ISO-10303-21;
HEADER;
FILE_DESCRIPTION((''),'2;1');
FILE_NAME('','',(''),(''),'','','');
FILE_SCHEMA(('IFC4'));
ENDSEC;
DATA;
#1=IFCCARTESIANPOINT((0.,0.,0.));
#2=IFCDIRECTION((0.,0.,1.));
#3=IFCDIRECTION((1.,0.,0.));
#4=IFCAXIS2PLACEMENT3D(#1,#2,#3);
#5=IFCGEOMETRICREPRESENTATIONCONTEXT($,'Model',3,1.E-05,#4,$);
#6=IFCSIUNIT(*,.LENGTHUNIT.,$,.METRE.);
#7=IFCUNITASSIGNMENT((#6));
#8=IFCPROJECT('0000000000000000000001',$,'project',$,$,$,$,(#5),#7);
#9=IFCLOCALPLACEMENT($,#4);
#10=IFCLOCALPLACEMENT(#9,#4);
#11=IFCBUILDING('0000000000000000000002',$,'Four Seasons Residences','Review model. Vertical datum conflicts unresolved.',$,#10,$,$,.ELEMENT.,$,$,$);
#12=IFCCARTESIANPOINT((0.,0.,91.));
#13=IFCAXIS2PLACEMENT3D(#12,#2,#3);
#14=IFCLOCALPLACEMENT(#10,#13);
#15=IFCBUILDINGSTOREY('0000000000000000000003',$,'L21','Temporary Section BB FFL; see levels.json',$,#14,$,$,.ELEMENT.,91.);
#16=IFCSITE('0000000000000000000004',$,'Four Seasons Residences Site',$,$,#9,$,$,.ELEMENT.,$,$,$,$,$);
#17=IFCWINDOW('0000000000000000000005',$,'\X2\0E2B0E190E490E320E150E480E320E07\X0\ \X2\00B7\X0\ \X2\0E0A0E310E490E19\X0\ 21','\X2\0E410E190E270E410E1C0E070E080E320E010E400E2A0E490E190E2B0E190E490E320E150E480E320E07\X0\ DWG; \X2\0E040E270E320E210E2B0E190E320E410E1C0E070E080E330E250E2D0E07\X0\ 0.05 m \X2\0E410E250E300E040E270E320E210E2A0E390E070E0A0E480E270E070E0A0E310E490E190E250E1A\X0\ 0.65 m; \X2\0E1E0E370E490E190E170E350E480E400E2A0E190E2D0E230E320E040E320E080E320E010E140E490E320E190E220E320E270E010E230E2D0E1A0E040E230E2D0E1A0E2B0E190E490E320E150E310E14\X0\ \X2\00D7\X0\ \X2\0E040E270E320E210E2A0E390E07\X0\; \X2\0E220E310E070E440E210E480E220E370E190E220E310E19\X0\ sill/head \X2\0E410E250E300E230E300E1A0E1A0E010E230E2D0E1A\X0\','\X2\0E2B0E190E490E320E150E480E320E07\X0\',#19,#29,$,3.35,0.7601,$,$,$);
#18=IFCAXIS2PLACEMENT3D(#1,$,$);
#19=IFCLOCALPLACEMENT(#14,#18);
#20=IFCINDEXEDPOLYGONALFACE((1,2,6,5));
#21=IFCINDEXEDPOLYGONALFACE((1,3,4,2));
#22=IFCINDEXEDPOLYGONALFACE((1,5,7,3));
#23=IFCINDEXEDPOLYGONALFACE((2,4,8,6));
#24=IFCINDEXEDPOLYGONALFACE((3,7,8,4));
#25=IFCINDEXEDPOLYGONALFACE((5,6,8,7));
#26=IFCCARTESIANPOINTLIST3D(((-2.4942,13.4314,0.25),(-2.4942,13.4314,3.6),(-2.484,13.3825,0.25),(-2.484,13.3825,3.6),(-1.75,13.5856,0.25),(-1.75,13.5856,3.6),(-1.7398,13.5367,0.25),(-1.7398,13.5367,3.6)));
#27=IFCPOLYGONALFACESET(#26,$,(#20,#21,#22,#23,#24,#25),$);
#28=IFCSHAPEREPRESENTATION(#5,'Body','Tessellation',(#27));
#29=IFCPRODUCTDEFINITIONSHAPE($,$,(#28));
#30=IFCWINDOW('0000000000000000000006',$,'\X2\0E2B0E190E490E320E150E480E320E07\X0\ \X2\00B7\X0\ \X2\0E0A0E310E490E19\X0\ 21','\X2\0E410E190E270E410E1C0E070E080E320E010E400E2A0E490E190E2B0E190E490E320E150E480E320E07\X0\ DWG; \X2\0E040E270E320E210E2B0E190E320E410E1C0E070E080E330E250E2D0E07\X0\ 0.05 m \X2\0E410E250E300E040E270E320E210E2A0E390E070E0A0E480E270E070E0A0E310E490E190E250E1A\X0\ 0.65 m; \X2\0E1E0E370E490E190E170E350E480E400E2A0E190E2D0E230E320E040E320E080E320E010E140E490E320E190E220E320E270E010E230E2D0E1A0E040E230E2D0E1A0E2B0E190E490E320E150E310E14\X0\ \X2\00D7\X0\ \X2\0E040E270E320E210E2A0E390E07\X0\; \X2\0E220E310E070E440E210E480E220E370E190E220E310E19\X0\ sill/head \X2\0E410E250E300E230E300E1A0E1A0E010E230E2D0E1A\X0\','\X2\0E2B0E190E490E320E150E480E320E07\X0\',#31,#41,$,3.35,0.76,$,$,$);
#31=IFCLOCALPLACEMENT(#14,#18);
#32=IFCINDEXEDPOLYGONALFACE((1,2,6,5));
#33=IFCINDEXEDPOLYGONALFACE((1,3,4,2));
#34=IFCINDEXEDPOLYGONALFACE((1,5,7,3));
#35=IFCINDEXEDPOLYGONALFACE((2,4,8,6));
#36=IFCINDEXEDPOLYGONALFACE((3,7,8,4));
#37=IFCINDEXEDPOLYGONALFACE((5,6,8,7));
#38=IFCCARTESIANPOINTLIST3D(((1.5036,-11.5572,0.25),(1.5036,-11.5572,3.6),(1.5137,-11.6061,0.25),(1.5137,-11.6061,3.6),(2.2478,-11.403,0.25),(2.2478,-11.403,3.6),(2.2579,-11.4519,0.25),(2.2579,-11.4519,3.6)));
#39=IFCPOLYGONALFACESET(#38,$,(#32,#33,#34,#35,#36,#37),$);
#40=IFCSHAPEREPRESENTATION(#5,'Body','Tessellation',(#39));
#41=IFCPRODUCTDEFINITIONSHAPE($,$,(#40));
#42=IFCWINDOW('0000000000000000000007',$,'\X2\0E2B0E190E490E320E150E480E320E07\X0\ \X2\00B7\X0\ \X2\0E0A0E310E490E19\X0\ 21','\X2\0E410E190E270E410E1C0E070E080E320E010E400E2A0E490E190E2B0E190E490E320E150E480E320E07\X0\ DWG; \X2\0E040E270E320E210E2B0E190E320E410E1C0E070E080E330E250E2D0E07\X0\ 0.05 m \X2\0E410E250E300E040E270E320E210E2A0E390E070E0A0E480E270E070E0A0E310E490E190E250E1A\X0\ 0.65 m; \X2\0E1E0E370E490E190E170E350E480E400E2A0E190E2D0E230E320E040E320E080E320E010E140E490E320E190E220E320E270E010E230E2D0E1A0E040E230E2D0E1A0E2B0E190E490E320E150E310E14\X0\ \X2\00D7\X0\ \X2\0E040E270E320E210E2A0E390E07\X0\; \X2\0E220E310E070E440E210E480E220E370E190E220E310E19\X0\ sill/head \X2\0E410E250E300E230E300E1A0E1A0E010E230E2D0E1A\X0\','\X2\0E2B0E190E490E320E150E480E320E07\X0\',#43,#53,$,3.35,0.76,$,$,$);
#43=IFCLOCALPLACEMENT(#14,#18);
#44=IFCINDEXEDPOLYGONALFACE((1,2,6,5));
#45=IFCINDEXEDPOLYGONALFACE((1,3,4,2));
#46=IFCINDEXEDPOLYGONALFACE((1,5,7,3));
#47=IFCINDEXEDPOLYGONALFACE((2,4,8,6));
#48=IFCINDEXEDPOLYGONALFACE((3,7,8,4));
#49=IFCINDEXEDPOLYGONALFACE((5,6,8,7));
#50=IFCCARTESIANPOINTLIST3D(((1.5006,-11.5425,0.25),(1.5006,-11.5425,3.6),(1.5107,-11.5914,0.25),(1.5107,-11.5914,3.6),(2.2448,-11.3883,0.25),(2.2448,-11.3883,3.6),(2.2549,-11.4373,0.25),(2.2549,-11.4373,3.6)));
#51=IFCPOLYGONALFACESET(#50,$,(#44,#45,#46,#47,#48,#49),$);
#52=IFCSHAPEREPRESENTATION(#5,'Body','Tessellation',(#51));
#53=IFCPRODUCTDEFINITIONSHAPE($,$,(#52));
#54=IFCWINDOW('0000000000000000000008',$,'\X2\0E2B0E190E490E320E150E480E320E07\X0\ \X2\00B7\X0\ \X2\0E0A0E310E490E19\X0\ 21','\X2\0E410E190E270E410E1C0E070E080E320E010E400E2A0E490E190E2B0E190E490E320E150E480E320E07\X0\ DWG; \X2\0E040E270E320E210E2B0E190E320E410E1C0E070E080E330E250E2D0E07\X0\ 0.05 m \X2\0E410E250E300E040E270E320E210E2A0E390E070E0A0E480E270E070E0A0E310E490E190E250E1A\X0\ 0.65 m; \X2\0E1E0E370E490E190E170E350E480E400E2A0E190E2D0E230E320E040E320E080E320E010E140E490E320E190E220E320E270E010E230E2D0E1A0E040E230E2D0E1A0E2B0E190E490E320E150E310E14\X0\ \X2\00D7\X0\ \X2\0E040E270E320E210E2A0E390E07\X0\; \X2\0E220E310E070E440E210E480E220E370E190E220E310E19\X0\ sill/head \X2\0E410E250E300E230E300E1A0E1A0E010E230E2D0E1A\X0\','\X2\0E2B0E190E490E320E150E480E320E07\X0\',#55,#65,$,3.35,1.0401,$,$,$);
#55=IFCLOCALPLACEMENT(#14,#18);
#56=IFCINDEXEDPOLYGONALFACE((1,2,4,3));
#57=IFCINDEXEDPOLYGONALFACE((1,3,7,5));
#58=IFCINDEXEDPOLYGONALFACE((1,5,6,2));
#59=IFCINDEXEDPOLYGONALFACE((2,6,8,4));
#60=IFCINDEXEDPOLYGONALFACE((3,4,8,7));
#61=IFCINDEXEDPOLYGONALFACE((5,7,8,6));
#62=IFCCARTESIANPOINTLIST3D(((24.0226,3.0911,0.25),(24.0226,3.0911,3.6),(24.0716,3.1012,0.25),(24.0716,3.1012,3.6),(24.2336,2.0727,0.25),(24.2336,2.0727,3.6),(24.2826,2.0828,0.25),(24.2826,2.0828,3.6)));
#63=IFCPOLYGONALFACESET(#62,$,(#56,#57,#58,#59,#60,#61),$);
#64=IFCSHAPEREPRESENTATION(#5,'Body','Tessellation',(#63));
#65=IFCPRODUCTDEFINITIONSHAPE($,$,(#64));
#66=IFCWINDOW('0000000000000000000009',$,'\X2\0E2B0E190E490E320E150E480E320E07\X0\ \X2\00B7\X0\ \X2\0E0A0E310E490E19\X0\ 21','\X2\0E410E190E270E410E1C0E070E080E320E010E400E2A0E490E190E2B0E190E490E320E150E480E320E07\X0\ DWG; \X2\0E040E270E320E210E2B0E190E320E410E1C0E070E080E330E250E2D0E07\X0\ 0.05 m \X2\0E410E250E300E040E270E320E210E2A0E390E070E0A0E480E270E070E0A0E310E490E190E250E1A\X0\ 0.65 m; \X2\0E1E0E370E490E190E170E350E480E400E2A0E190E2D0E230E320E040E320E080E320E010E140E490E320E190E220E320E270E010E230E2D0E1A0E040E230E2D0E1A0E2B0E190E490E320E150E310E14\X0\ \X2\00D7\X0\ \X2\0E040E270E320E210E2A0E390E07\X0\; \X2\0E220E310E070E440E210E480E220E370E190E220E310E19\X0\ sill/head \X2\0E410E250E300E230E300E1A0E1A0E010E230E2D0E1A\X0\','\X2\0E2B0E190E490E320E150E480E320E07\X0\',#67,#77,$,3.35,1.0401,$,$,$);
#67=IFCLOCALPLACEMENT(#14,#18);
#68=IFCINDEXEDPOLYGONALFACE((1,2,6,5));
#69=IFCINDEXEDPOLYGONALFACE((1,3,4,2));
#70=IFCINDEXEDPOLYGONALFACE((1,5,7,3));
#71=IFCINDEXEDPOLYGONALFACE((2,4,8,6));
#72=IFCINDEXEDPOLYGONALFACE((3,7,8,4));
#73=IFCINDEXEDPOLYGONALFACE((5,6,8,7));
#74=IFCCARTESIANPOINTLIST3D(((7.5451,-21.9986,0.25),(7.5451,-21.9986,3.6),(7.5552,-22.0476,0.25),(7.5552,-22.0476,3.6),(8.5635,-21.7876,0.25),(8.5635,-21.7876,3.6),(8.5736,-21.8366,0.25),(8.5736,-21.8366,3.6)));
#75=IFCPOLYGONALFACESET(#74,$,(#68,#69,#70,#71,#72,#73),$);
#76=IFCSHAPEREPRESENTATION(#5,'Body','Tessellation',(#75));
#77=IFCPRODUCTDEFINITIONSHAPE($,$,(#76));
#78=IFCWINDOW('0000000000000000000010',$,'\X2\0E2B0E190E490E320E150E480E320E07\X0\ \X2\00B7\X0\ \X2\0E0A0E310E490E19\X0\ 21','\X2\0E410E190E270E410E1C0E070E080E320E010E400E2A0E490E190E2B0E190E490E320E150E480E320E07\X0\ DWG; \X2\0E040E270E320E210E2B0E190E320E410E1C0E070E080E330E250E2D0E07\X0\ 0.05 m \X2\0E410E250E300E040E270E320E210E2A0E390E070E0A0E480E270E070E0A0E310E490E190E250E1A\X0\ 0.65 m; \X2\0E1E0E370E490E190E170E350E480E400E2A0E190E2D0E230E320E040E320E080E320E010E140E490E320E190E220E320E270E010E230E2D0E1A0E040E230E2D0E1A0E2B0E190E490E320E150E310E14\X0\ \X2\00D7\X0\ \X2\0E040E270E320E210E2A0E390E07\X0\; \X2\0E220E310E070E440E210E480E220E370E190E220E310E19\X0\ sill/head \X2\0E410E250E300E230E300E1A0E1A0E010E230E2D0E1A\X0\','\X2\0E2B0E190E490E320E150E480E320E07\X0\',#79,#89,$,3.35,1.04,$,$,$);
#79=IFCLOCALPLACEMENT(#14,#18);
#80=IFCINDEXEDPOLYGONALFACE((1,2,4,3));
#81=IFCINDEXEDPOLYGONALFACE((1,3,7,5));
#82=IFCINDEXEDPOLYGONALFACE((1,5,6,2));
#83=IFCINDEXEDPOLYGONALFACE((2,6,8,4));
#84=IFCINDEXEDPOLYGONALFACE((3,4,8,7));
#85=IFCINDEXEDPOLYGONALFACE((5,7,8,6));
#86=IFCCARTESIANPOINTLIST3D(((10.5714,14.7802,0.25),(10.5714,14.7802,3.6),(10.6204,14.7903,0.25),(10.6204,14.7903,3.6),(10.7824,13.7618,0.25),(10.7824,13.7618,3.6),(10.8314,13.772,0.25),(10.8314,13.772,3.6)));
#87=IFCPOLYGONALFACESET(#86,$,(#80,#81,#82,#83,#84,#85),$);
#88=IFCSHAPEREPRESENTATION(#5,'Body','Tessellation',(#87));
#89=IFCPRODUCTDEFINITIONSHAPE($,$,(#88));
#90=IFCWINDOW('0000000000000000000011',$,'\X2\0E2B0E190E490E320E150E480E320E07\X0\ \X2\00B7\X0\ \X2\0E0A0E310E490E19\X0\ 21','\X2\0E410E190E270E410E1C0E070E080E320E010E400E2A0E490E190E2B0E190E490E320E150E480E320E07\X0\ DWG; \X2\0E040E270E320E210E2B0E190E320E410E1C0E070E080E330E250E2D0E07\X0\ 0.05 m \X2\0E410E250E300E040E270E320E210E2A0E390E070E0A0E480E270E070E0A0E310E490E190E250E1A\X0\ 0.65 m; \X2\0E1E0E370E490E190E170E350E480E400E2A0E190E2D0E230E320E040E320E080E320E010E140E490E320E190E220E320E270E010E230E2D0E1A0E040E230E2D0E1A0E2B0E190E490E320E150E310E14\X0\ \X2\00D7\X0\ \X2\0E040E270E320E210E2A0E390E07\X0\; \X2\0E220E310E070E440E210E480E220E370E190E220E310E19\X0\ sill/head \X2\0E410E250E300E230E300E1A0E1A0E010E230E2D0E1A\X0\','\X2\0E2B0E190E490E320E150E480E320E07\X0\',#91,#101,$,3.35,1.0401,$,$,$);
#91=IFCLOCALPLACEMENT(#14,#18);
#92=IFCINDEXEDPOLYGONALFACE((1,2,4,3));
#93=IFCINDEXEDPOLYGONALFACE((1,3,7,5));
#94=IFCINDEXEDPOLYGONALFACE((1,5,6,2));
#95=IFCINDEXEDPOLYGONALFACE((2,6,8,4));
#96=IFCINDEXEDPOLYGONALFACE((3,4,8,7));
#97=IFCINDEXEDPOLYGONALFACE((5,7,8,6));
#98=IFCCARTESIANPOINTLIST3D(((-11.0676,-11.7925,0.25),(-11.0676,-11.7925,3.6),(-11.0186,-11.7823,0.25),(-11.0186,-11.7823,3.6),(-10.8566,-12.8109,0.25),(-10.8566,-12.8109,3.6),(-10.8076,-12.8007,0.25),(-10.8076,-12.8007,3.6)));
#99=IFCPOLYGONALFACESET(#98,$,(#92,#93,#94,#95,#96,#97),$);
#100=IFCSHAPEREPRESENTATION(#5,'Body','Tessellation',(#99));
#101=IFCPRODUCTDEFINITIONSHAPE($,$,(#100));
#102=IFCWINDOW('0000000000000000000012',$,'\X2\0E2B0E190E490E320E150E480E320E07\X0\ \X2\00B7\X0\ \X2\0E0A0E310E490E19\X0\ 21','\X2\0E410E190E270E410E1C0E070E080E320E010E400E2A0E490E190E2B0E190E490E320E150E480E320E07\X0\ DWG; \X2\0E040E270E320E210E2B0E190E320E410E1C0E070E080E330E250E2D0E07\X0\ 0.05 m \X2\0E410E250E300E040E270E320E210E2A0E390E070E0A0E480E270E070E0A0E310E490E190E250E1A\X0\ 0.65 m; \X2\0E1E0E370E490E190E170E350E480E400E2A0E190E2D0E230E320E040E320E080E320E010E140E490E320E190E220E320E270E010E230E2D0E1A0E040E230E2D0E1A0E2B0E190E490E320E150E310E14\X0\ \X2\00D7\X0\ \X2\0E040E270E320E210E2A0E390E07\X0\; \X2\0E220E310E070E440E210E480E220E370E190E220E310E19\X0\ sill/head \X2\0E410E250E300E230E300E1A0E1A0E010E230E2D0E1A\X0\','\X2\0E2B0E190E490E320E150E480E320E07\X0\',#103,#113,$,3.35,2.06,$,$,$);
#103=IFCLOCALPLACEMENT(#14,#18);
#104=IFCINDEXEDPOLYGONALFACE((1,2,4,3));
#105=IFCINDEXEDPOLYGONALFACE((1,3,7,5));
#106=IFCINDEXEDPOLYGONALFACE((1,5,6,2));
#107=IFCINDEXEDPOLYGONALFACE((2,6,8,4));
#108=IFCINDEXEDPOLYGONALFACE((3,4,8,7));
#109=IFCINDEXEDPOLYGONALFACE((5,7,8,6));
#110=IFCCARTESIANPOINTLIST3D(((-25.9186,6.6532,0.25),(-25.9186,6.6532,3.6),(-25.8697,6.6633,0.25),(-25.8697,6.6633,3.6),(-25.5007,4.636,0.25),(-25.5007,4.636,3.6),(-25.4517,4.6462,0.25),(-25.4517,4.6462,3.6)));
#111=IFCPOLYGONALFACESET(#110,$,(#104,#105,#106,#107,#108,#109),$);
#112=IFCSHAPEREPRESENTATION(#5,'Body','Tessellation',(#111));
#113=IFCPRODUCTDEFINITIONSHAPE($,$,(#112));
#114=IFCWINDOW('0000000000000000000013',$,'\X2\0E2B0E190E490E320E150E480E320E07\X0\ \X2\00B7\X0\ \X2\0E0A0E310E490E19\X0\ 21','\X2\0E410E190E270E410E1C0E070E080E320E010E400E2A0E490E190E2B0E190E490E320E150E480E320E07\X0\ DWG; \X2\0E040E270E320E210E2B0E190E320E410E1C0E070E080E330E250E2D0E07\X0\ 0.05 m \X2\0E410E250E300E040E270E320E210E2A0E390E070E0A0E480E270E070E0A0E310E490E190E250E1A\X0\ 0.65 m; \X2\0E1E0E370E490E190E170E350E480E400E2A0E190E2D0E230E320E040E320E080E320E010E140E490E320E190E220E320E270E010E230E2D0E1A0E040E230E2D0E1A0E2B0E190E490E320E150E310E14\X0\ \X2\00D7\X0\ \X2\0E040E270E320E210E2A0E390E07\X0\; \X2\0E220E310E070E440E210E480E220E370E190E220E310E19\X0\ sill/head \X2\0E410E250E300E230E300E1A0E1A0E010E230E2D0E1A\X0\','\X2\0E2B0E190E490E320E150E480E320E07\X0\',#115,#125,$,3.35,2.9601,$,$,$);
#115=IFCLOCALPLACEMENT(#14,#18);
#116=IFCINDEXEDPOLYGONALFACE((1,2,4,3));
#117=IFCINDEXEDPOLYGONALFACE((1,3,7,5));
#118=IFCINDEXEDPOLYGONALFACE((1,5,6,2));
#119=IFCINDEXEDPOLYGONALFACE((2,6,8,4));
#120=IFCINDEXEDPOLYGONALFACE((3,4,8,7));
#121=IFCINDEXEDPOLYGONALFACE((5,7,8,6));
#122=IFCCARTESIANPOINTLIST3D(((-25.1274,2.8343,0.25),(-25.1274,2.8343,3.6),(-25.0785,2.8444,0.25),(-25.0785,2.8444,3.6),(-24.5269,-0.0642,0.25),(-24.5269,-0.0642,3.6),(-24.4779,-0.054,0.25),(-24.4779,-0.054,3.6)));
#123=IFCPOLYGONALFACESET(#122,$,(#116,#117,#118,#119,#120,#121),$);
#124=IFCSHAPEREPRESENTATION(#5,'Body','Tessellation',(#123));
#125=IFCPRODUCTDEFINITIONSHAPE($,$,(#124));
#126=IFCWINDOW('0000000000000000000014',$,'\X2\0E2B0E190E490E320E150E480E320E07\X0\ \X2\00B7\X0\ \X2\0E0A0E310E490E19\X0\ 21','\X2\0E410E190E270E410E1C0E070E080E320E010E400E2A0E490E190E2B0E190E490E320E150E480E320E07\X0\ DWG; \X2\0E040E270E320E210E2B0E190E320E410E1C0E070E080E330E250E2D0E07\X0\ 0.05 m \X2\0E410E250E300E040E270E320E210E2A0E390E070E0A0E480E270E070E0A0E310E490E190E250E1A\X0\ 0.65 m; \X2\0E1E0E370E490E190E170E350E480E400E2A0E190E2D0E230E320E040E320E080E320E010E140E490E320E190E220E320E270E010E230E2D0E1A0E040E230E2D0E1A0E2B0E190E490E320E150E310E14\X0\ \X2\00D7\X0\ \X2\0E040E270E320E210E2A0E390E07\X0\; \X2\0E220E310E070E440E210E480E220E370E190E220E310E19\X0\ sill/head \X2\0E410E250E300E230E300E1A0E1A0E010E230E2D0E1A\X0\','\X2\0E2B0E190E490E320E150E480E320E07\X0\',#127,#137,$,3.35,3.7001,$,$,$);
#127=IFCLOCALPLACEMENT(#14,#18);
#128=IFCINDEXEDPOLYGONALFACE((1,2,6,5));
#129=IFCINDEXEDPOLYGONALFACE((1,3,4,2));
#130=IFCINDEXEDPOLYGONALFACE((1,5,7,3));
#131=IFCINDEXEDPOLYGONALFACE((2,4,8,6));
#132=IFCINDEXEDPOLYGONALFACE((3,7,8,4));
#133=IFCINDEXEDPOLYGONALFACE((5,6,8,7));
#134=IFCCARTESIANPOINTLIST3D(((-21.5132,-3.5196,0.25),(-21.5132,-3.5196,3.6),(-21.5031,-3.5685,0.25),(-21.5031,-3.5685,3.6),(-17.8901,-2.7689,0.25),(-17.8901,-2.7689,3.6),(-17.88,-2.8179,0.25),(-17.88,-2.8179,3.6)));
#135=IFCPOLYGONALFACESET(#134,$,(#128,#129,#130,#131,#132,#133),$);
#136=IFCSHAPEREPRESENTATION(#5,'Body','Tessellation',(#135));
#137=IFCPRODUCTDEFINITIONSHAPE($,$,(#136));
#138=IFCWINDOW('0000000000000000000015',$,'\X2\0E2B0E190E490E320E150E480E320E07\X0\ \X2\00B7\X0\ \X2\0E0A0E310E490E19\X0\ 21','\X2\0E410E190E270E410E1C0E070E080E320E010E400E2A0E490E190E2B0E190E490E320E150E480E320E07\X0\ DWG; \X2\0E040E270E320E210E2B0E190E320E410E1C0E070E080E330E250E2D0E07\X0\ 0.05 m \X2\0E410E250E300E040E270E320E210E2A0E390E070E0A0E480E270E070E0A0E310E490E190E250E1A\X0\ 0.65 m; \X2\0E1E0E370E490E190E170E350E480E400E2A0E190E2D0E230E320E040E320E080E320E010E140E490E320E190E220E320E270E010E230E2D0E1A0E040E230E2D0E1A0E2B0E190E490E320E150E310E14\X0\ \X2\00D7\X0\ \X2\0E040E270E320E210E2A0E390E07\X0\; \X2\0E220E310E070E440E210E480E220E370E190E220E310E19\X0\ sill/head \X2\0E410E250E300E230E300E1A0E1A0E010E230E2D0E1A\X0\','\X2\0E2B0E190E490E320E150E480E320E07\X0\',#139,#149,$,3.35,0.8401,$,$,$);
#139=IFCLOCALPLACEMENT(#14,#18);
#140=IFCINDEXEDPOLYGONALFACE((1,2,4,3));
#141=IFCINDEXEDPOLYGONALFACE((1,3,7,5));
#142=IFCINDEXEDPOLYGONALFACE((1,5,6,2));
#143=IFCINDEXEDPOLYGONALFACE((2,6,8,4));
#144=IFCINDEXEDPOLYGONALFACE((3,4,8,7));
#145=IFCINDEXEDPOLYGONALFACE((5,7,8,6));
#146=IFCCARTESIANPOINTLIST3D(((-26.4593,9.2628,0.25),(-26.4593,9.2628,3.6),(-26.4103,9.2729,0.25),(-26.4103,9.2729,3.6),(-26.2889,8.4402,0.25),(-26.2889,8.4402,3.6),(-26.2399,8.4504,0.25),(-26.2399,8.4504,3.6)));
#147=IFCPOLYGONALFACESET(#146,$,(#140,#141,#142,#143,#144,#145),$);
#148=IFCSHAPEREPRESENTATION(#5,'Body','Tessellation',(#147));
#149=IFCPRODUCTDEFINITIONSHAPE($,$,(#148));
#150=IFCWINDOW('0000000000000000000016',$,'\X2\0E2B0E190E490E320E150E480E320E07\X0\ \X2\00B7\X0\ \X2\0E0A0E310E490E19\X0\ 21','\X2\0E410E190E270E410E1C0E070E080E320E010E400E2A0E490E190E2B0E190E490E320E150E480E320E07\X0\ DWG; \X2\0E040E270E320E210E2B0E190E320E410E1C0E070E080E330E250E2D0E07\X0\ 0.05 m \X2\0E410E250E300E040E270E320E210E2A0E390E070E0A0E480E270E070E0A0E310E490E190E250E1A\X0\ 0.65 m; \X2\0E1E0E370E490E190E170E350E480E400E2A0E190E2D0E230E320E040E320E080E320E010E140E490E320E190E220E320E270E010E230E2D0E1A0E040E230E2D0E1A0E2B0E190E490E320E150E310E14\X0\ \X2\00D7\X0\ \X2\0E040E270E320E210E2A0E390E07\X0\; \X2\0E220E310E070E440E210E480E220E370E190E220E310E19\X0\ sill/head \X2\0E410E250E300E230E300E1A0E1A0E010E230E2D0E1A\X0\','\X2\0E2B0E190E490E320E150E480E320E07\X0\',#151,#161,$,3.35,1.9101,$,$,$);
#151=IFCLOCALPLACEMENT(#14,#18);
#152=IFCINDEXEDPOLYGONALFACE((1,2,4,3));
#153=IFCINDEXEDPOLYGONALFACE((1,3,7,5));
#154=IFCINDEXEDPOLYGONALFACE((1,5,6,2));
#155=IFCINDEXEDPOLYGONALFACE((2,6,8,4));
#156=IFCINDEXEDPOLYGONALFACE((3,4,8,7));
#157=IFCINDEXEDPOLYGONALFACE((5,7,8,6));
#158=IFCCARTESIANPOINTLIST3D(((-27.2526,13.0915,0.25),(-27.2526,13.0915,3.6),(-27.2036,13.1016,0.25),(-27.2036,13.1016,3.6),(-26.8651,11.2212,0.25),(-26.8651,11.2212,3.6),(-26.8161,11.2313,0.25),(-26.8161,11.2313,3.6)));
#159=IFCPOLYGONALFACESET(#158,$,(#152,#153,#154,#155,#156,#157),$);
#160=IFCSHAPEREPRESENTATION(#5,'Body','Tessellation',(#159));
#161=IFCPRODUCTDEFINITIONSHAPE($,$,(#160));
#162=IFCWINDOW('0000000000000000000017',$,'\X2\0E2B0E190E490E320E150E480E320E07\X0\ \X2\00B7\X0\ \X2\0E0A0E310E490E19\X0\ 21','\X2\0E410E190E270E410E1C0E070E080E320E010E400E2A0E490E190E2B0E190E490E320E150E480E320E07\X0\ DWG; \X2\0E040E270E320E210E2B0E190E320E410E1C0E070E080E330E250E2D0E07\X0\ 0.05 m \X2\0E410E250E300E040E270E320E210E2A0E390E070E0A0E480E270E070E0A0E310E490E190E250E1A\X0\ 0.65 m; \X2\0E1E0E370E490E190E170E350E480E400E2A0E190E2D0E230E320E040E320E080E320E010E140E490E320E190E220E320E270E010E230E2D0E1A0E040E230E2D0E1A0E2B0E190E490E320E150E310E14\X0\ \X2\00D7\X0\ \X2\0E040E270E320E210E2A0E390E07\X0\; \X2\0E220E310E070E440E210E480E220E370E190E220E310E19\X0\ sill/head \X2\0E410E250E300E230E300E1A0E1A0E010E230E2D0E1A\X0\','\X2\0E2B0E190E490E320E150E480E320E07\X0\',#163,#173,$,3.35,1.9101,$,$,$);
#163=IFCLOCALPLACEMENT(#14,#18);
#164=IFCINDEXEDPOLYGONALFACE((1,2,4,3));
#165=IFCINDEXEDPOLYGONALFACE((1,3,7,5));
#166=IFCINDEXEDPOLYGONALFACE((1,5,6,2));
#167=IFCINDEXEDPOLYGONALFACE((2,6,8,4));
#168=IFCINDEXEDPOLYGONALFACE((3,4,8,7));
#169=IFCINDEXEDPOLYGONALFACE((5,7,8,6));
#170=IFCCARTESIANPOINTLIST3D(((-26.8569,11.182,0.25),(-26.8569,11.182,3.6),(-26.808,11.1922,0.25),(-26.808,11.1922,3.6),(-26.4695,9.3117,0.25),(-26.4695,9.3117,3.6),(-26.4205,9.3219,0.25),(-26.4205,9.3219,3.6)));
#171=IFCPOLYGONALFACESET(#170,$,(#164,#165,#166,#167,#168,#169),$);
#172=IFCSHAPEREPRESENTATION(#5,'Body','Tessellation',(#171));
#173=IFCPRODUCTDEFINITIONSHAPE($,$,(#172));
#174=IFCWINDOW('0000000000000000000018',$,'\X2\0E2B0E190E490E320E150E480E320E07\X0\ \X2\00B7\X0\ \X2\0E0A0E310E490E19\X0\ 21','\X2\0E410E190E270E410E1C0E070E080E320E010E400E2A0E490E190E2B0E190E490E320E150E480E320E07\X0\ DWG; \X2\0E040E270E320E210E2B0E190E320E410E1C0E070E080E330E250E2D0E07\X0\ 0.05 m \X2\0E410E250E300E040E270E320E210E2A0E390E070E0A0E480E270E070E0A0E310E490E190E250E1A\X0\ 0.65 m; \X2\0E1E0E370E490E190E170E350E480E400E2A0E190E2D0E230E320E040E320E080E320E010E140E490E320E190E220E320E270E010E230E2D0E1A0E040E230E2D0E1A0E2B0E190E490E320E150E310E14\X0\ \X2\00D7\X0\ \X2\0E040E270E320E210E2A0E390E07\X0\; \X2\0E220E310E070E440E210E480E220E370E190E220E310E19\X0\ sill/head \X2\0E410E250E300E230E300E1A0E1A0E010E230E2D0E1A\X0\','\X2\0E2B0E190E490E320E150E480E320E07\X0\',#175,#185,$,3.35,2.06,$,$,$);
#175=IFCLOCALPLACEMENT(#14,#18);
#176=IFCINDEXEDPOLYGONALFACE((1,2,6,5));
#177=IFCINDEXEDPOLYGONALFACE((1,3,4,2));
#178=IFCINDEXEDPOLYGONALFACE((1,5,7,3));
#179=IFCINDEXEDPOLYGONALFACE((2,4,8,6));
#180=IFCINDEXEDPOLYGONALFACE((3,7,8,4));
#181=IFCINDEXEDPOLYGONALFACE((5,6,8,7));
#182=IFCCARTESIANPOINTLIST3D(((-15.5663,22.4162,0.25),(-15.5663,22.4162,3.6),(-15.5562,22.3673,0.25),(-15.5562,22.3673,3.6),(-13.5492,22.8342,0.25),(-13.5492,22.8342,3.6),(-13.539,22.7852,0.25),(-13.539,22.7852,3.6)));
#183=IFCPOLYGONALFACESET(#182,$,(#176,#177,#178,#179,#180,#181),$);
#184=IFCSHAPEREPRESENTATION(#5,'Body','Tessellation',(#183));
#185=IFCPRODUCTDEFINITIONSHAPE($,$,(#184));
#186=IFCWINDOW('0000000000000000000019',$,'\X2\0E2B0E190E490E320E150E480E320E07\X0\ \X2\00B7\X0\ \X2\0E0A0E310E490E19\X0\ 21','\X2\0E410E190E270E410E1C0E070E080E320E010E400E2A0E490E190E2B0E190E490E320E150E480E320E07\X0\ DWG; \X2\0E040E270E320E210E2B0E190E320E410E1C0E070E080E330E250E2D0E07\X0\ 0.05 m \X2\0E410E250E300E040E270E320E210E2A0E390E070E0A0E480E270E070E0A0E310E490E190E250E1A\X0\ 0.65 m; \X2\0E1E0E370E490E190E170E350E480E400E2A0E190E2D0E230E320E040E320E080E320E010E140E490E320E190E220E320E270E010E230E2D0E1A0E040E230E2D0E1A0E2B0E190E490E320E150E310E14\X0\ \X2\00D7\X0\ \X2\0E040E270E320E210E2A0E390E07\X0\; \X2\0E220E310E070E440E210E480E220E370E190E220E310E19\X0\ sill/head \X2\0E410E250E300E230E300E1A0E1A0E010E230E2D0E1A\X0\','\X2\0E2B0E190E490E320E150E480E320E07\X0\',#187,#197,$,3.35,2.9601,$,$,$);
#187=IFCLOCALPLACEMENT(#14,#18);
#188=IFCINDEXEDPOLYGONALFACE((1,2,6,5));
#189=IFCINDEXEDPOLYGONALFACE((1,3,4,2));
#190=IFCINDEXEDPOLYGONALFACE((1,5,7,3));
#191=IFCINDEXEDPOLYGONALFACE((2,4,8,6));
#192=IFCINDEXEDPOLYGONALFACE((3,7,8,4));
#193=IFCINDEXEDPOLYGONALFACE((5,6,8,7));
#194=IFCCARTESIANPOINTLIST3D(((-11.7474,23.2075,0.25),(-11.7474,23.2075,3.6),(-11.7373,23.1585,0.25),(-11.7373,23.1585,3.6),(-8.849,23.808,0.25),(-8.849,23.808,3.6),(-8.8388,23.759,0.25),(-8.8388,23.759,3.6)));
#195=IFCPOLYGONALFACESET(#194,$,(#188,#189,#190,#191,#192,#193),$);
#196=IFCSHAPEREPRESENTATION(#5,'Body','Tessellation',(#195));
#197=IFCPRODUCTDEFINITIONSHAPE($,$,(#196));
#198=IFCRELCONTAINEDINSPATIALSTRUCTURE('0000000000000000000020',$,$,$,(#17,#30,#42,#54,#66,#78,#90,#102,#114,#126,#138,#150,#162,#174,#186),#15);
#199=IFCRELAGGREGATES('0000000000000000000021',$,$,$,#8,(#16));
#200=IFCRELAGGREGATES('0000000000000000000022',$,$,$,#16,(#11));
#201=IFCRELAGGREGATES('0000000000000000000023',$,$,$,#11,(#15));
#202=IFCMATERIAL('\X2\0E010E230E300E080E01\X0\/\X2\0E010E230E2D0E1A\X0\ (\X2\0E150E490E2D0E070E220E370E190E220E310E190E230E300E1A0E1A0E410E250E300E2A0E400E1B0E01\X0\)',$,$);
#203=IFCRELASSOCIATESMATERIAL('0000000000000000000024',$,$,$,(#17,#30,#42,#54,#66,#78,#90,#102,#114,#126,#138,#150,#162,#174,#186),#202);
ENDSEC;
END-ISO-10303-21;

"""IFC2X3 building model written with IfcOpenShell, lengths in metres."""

from ifc_helpers import new_model, si_unit, frame, origin_with_axes, place, context, project, spatial, polyline, outline, extrude, material, element, save


model = new_model("IFC2X3")

# Units and contexts
model_context = context("Model", 3, precision=1e-05, world=origin_with_axes())
ifc_project = project(units=[si_unit("LENGTHUNIT", "METRE")], contexts=[model_context])

# Site, building, storey
site_placement = place(None, origin_with_axes())
site = spatial("IfcSite", under=ifc_project, at=site_placement, Name="Four Seasons Residences Site", CompositionType="ELEMENT")
building_placement = place(site_placement, origin_with_axes())
building = spatial("IfcBuilding", under=site, at=building_placement, Name="Four Seasons Residences", Description="Review model. Vertical datum conflicts unresolved.", CompositionType="ELEMENT")
storey_placement = place(building_placement, frame((0.0, 0.0, 91.0), z_axis=(0.0, 0.0, 1.0), x_axis=(1.0, 0.0, 0.0)))
storey = spatial("IfcBuildingStorey", under=building, at=storey_placement, Name="L21", Description="Temporary Section BB FFL; see levels.json", CompositionType="ELEMENT", Elevation=91.0)

# Windows
ifc_material = material(Name="กระจก/กรอบ (ต้องยืนยันระบบและสเปก)")
window_1_placement = place(storey_placement, origin_with_axes())
element("IfcWindow", 1, at=window_1_placement, inside=storey, material=ifc_material, Name="หน้าต่าง · ชั้น 21", Description="แนวแผงจากเส้นหน้าต่าง DWG; ความหนาแผงจำลอง 0.05 m และความสูงช่วงชั้นลบ 0.65 m; พื้นที่เสนอราคาจากด้านยาวกรอบครอบหน้าตัด × ความสูง; ยังไม่ยืนยัน sill/head และระบบกรอบ", ObjectType="หน้าต่าง", OverallHeight=3.35, OverallWidth=0.7601, context=model_context, shape_type="SweptSolid", body=[
    extrude(outline(polyline([(-1.75, 13.5856), (-1.7398, 13.5367), (-2.484, 13.3825), (-2.4942, 13.4314), (-1.75, 13.5856)])), frame((0.0, 0.0, 0.25), z_axis=(0.0, 0.0, 1.0), x_axis=(1.0, 0.0, 0.0)), (0.0, 0.0, 1.0), 3.35),
])
window_2_placement = place(storey_placement, origin_with_axes())
element("IfcWindow", 2, at=window_2_placement, inside=storey, material=ifc_material, Name="หน้าต่าง · ชั้น 21", Description="แนวแผงจากเส้นหน้าต่าง DWG; ความหนาแผงจำลอง 0.05 m และความสูงช่วงชั้นลบ 0.65 m; พื้นที่เสนอราคาจากด้านยาวกรอบครอบหน้าตัด × ความสูง; ยังไม่ยืนยัน sill/head และระบบกรอบ", ObjectType="หน้าต่าง", OverallHeight=3.35, OverallWidth=0.76, context=model_context, shape_type="SweptSolid", body=[
    extrude(outline(polyline([(2.2478, -11.403), (2.2579, -11.4519), (1.5137, -11.6061), (1.5036, -11.5572), (2.2478, -11.403)])), frame((0.0, 0.0, 0.25), z_axis=(0.0, 0.0, 1.0), x_axis=(1.0, 0.0, 0.0)), (0.0, 0.0, 1.0), 3.35),
])
window_3_placement = place(storey_placement, origin_with_axes())
element("IfcWindow", 3, at=window_3_placement, inside=storey, material=ifc_material, Name="หน้าต่าง · ชั้น 21", Description="แนวแผงจากเส้นหน้าต่าง DWG; ความหนาแผงจำลอง 0.05 m และความสูงช่วงชั้นลบ 0.65 m; พื้นที่เสนอราคาจากด้านยาวกรอบครอบหน้าตัด × ความสูง; ยังไม่ยืนยัน sill/head และระบบกรอบ", ObjectType="หน้าต่าง", OverallHeight=3.35, OverallWidth=0.76, context=model_context, shape_type="SweptSolid", body=[
    extrude(outline(polyline([(2.2448, -11.3883), (2.2549, -11.4373), (1.5107, -11.5914), (1.5006, -11.5425), (2.2448, -11.3883)])), frame((0.0, 0.0, 0.25), z_axis=(0.0, 0.0, 1.0), x_axis=(1.0, 0.0, 0.0)), (0.0, 0.0, 1.0), 3.35),
])
window_4_placement = place(storey_placement, origin_with_axes())
element("IfcWindow", 4, at=window_4_placement, inside=storey, material=ifc_material, Name="หน้าต่าง · ชั้น 21", Description="แนวแผงจากเส้นหน้าต่าง DWG; ความหนาแผงจำลอง 0.05 m และความสูงช่วงชั้นลบ 0.65 m; พื้นที่เสนอราคาจากด้านยาวกรอบครอบหน้าตัด × ความสูง; ยังไม่ยืนยัน sill/head และระบบกรอบ", ObjectType="หน้าต่าง", OverallHeight=3.35, OverallWidth=1.0401, context=model_context, shape_type="SweptSolid", body=[
    extrude(outline(polyline([(24.0226, 3.0911), (24.0716, 3.1012), (24.2826, 2.0828), (24.2336, 2.0727), (24.0226, 3.0911)])), frame((0.0, 0.0, 0.25), z_axis=(0.0, 0.0, 1.0), x_axis=(1.0, 0.0, 0.0)), (0.0, 0.0, 1.0), 3.35),
])
window_5_placement = place(storey_placement, origin_with_axes())
element("IfcWindow", 5, at=window_5_placement, inside=storey, material=ifc_material, Name="หน้าต่าง · ชั้น 21", Description="แนวแผงจากเส้นหน้าต่าง DWG; ความหนาแผงจำลอง 0.05 m และความสูงช่วงชั้นลบ 0.65 m; พื้นที่เสนอราคาจากด้านยาวกรอบครอบหน้าตัด × ความสูง; ยังไม่ยืนยัน sill/head และระบบกรอบ", ObjectType="หน้าต่าง", OverallHeight=3.35, OverallWidth=1.0401, context=model_context, shape_type="SweptSolid", body=[
    extrude(outline(polyline([(7.5552, -22.0476), (7.5451, -21.9986), (8.5635, -21.7876), (8.5736, -21.8366), (7.5552, -22.0476)])), frame((0.0, 0.0, 0.25), z_axis=(0.0, 0.0, 1.0), x_axis=(1.0, 0.0, 0.0)), (0.0, 0.0, 1.0), 3.35),
])
window_6_placement = place(storey_placement, origin_with_axes())
element("IfcWindow", 6, at=window_6_placement, inside=storey, material=ifc_material, Name="หน้าต่าง · ชั้น 21", Description="แนวแผงจากเส้นหน้าต่าง DWG; ความหนาแผงจำลอง 0.05 m และความสูงช่วงชั้นลบ 0.65 m; พื้นที่เสนอราคาจากด้านยาวกรอบครอบหน้าตัด × ความสูง; ยังไม่ยืนยัน sill/head และระบบกรอบ", ObjectType="หน้าต่าง", OverallHeight=3.35, OverallWidth=1.04, context=model_context, shape_type="SweptSolid", body=[
    extrude(outline(polyline([(10.5714, 14.7802), (10.6204, 14.7903), (10.8314, 13.772), (10.7824, 13.7618), (10.5714, 14.7802)])), frame((0.0, 0.0, 0.25), z_axis=(0.0, 0.0, 1.0), x_axis=(1.0, 0.0, 0.0)), (0.0, 0.0, 1.0), 3.35),
])
window_7_placement = place(storey_placement, origin_with_axes())
element("IfcWindow", 7, at=window_7_placement, inside=storey, material=ifc_material, Name="หน้าต่าง · ชั้น 21", Description="แนวแผงจากเส้นหน้าต่าง DWG; ความหนาแผงจำลอง 0.05 m และความสูงช่วงชั้นลบ 0.65 m; พื้นที่เสนอราคาจากด้านยาวกรอบครอบหน้าตัด × ความสูง; ยังไม่ยืนยัน sill/head และระบบกรอบ", ObjectType="หน้าต่าง", OverallHeight=3.35, OverallWidth=1.0401, context=model_context, shape_type="SweptSolid", body=[
    extrude(outline(polyline([(-10.8076, -12.8007), (-10.8566, -12.8109), (-11.0676, -11.7925), (-11.0186, -11.7823), (-10.8076, -12.8007)])), frame((0.0, 0.0, 0.25), z_axis=(0.0, 0.0, 1.0), x_axis=(1.0, 0.0, 0.0)), (0.0, 0.0, 1.0), 3.35),
])
window_8_placement = place(storey_placement, origin_with_axes())
element("IfcWindow", 8, at=window_8_placement, inside=storey, material=ifc_material, Name="หน้าต่าง · ชั้น 21", Description="แนวแผงจากเส้นหน้าต่าง DWG; ความหนาแผงจำลอง 0.05 m และความสูงช่วงชั้นลบ 0.65 m; พื้นที่เสนอราคาจากด้านยาวกรอบครอบหน้าตัด × ความสูง; ยังไม่ยืนยัน sill/head และระบบกรอบ", ObjectType="หน้าต่าง", OverallHeight=3.35, OverallWidth=2.06, context=model_context, shape_type="SweptSolid", body=[
    extrude(outline(polyline([(-25.4517, 4.6462), (-25.5007, 4.636), (-25.9186, 6.6532), (-25.8697, 6.6633), (-25.4517, 4.6462)])), frame((0.0, 0.0, 0.25), z_axis=(0.0, 0.0, 1.0), x_axis=(1.0, 0.0, 0.0)), (0.0, 0.0, 1.0), 3.35),
])
window_9_placement = place(storey_placement, origin_with_axes())
element("IfcWindow", 9, at=window_9_placement, inside=storey, material=ifc_material, Name="หน้าต่าง · ชั้น 21", Description="แนวแผงจากเส้นหน้าต่าง DWG; ความหนาแผงจำลอง 0.05 m และความสูงช่วงชั้นลบ 0.65 m; พื้นที่เสนอราคาจากด้านยาวกรอบครอบหน้าตัด × ความสูง; ยังไม่ยืนยัน sill/head และระบบกรอบ", ObjectType="หน้าต่าง", OverallHeight=3.35, OverallWidth=2.9601, context=model_context, shape_type="SweptSolid", body=[
    extrude(outline(polyline([(-24.4779, -0.054), (-24.5269, -0.0642), (-25.1274, 2.8343), (-25.0785, 2.8444), (-24.4779, -0.054)])), frame((0.0, 0.0, 0.25), z_axis=(0.0, 0.0, 1.0), x_axis=(1.0, 0.0, 0.0)), (0.0, 0.0, 1.0), 3.35),
])
window_10_placement = place(storey_placement, origin_with_axes())
element("IfcWindow", 10, at=window_10_placement, inside=storey, material=ifc_material, Name="หน้าต่าง · ชั้น 21", Description="แนวแผงจากเส้นหน้าต่าง DWG; ความหนาแผงจำลอง 0.05 m และความสูงช่วงชั้นลบ 0.65 m; พื้นที่เสนอราคาจากด้านยาวกรอบครอบหน้าตัด × ความสูง; ยังไม่ยืนยัน sill/head และระบบกรอบ", ObjectType="หน้าต่าง", OverallHeight=3.35, OverallWidth=3.7001, context=model_context, shape_type="SweptSolid", body=[
    extrude(outline(polyline([(-17.8901, -2.7689), (-17.88, -2.8179), (-21.5031, -3.5685), (-21.5132, -3.5196), (-17.8901, -2.7689)])), frame((0.0, 0.0, 0.25), z_axis=(0.0, 0.0, 1.0), x_axis=(1.0, 0.0, 0.0)), (0.0, 0.0, 1.0), 3.35),
])
window_11_placement = place(storey_placement, origin_with_axes())
element("IfcWindow", 11, at=window_11_placement, inside=storey, material=ifc_material, Name="หน้าต่าง · ชั้น 21", Description="แนวแผงจากเส้นหน้าต่าง DWG; ความหนาแผงจำลอง 0.05 m และความสูงช่วงชั้นลบ 0.65 m; พื้นที่เสนอราคาจากด้านยาวกรอบครอบหน้าตัด × ความสูง; ยังไม่ยืนยัน sill/head และระบบกรอบ", ObjectType="หน้าต่าง", OverallHeight=3.35, OverallWidth=0.8401, context=model_context, shape_type="SweptSolid", body=[
    extrude(outline(polyline([(-26.2399, 8.4504), (-26.2889, 8.4402), (-26.4593, 9.2628), (-26.4103, 9.2729), (-26.2399, 8.4504)])), frame((0.0, 0.0, 0.25), z_axis=(0.0, 0.0, 1.0), x_axis=(1.0, 0.0, 0.0)), (0.0, 0.0, 1.0), 3.35),
])
window_12_placement = place(storey_placement, origin_with_axes())
element("IfcWindow", 12, at=window_12_placement, inside=storey, material=ifc_material, Name="หน้าต่าง · ชั้น 21", Description="แนวแผงจากเส้นหน้าต่าง DWG; ความหนาแผงจำลอง 0.05 m และความสูงช่วงชั้นลบ 0.65 m; พื้นที่เสนอราคาจากด้านยาวกรอบครอบหน้าตัด × ความสูง; ยังไม่ยืนยัน sill/head และระบบกรอบ", ObjectType="หน้าต่าง", OverallHeight=3.35, OverallWidth=1.9101, context=model_context, shape_type="SweptSolid", body=[
    extrude(outline(polyline([(-26.8161, 11.2313), (-26.8651, 11.2212), (-27.2526, 13.0915), (-27.2036, 13.1016), (-26.8161, 11.2313)])), frame((0.0, 0.0, 0.25), z_axis=(0.0, 0.0, 1.0), x_axis=(1.0, 0.0, 0.0)), (0.0, 0.0, 1.0), 3.35),
])
window_13_placement = place(storey_placement, origin_with_axes())
element("IfcWindow", 13, at=window_13_placement, inside=storey, material=ifc_material, Name="หน้าต่าง · ชั้น 21", Description="แนวแผงจากเส้นหน้าต่าง DWG; ความหนาแผงจำลอง 0.05 m และความสูงช่วงชั้นลบ 0.65 m; พื้นที่เสนอราคาจากด้านยาวกรอบครอบหน้าตัด × ความสูง; ยังไม่ยืนยัน sill/head และระบบกรอบ", ObjectType="หน้าต่าง", OverallHeight=3.35, OverallWidth=1.9101, context=model_context, shape_type="SweptSolid", body=[
    extrude(outline(polyline([(-26.4205, 9.3219), (-26.4695, 9.3117), (-26.8569, 11.182), (-26.808, 11.1922), (-26.4205, 9.3219)])), frame((0.0, 0.0, 0.25), z_axis=(0.0, 0.0, 1.0), x_axis=(1.0, 0.0, 0.0)), (0.0, 0.0, 1.0), 3.35),
])
window_14_placement = place(storey_placement, origin_with_axes())
element("IfcWindow", 14, at=window_14_placement, inside=storey, material=ifc_material, Name="หน้าต่าง · ชั้น 21", Description="แนวแผงจากเส้นหน้าต่าง DWG; ความหนาแผงจำลอง 0.05 m และความสูงช่วงชั้นลบ 0.65 m; พื้นที่เสนอราคาจากด้านยาวกรอบครอบหน้าตัด × ความสูง; ยังไม่ยืนยัน sill/head และระบบกรอบ", ObjectType="หน้าต่าง", OverallHeight=3.35, OverallWidth=2.06, context=model_context, shape_type="SweptSolid", body=[
    extrude(outline(polyline([(-13.5492, 22.8342), (-13.539, 22.7852), (-15.5562, 22.3673), (-15.5663, 22.4162), (-13.5492, 22.8342)])), frame((0.0, 0.0, 0.25), z_axis=(0.0, 0.0, 1.0), x_axis=(1.0, 0.0, 0.0)), (0.0, 0.0, 1.0), 3.35),
])
window_15_placement = place(storey_placement, origin_with_axes())
element("IfcWindow", 15, at=window_15_placement, inside=storey, material=ifc_material, Name="หน้าต่าง · ชั้น 21", Description="แนวแผงจากเส้นหน้าต่าง DWG; ความหนาแผงจำลอง 0.05 m และความสูงช่วงชั้นลบ 0.65 m; พื้นที่เสนอราคาจากด้านยาวกรอบครอบหน้าตัด × ความสูง; ยังไม่ยืนยัน sill/head และระบบกรอบ", ObjectType="หน้าต่าง", OverallHeight=3.35, OverallWidth=2.9601, context=model_context, shape_type="SweptSolid", body=[
    extrude(outline(polyline([(-8.849, 23.808), (-8.8388, 23.759), (-11.7373, 23.1585), (-11.7474, 23.2075), (-8.849, 23.808)])), frame((0.0, 0.0, 0.25), z_axis=(0.0, 0.0, 1.0), x_axis=(1.0, 0.0, 0.0)), (0.0, 0.0, 1.0), 3.35),
])

save(model, "model.ifc")
